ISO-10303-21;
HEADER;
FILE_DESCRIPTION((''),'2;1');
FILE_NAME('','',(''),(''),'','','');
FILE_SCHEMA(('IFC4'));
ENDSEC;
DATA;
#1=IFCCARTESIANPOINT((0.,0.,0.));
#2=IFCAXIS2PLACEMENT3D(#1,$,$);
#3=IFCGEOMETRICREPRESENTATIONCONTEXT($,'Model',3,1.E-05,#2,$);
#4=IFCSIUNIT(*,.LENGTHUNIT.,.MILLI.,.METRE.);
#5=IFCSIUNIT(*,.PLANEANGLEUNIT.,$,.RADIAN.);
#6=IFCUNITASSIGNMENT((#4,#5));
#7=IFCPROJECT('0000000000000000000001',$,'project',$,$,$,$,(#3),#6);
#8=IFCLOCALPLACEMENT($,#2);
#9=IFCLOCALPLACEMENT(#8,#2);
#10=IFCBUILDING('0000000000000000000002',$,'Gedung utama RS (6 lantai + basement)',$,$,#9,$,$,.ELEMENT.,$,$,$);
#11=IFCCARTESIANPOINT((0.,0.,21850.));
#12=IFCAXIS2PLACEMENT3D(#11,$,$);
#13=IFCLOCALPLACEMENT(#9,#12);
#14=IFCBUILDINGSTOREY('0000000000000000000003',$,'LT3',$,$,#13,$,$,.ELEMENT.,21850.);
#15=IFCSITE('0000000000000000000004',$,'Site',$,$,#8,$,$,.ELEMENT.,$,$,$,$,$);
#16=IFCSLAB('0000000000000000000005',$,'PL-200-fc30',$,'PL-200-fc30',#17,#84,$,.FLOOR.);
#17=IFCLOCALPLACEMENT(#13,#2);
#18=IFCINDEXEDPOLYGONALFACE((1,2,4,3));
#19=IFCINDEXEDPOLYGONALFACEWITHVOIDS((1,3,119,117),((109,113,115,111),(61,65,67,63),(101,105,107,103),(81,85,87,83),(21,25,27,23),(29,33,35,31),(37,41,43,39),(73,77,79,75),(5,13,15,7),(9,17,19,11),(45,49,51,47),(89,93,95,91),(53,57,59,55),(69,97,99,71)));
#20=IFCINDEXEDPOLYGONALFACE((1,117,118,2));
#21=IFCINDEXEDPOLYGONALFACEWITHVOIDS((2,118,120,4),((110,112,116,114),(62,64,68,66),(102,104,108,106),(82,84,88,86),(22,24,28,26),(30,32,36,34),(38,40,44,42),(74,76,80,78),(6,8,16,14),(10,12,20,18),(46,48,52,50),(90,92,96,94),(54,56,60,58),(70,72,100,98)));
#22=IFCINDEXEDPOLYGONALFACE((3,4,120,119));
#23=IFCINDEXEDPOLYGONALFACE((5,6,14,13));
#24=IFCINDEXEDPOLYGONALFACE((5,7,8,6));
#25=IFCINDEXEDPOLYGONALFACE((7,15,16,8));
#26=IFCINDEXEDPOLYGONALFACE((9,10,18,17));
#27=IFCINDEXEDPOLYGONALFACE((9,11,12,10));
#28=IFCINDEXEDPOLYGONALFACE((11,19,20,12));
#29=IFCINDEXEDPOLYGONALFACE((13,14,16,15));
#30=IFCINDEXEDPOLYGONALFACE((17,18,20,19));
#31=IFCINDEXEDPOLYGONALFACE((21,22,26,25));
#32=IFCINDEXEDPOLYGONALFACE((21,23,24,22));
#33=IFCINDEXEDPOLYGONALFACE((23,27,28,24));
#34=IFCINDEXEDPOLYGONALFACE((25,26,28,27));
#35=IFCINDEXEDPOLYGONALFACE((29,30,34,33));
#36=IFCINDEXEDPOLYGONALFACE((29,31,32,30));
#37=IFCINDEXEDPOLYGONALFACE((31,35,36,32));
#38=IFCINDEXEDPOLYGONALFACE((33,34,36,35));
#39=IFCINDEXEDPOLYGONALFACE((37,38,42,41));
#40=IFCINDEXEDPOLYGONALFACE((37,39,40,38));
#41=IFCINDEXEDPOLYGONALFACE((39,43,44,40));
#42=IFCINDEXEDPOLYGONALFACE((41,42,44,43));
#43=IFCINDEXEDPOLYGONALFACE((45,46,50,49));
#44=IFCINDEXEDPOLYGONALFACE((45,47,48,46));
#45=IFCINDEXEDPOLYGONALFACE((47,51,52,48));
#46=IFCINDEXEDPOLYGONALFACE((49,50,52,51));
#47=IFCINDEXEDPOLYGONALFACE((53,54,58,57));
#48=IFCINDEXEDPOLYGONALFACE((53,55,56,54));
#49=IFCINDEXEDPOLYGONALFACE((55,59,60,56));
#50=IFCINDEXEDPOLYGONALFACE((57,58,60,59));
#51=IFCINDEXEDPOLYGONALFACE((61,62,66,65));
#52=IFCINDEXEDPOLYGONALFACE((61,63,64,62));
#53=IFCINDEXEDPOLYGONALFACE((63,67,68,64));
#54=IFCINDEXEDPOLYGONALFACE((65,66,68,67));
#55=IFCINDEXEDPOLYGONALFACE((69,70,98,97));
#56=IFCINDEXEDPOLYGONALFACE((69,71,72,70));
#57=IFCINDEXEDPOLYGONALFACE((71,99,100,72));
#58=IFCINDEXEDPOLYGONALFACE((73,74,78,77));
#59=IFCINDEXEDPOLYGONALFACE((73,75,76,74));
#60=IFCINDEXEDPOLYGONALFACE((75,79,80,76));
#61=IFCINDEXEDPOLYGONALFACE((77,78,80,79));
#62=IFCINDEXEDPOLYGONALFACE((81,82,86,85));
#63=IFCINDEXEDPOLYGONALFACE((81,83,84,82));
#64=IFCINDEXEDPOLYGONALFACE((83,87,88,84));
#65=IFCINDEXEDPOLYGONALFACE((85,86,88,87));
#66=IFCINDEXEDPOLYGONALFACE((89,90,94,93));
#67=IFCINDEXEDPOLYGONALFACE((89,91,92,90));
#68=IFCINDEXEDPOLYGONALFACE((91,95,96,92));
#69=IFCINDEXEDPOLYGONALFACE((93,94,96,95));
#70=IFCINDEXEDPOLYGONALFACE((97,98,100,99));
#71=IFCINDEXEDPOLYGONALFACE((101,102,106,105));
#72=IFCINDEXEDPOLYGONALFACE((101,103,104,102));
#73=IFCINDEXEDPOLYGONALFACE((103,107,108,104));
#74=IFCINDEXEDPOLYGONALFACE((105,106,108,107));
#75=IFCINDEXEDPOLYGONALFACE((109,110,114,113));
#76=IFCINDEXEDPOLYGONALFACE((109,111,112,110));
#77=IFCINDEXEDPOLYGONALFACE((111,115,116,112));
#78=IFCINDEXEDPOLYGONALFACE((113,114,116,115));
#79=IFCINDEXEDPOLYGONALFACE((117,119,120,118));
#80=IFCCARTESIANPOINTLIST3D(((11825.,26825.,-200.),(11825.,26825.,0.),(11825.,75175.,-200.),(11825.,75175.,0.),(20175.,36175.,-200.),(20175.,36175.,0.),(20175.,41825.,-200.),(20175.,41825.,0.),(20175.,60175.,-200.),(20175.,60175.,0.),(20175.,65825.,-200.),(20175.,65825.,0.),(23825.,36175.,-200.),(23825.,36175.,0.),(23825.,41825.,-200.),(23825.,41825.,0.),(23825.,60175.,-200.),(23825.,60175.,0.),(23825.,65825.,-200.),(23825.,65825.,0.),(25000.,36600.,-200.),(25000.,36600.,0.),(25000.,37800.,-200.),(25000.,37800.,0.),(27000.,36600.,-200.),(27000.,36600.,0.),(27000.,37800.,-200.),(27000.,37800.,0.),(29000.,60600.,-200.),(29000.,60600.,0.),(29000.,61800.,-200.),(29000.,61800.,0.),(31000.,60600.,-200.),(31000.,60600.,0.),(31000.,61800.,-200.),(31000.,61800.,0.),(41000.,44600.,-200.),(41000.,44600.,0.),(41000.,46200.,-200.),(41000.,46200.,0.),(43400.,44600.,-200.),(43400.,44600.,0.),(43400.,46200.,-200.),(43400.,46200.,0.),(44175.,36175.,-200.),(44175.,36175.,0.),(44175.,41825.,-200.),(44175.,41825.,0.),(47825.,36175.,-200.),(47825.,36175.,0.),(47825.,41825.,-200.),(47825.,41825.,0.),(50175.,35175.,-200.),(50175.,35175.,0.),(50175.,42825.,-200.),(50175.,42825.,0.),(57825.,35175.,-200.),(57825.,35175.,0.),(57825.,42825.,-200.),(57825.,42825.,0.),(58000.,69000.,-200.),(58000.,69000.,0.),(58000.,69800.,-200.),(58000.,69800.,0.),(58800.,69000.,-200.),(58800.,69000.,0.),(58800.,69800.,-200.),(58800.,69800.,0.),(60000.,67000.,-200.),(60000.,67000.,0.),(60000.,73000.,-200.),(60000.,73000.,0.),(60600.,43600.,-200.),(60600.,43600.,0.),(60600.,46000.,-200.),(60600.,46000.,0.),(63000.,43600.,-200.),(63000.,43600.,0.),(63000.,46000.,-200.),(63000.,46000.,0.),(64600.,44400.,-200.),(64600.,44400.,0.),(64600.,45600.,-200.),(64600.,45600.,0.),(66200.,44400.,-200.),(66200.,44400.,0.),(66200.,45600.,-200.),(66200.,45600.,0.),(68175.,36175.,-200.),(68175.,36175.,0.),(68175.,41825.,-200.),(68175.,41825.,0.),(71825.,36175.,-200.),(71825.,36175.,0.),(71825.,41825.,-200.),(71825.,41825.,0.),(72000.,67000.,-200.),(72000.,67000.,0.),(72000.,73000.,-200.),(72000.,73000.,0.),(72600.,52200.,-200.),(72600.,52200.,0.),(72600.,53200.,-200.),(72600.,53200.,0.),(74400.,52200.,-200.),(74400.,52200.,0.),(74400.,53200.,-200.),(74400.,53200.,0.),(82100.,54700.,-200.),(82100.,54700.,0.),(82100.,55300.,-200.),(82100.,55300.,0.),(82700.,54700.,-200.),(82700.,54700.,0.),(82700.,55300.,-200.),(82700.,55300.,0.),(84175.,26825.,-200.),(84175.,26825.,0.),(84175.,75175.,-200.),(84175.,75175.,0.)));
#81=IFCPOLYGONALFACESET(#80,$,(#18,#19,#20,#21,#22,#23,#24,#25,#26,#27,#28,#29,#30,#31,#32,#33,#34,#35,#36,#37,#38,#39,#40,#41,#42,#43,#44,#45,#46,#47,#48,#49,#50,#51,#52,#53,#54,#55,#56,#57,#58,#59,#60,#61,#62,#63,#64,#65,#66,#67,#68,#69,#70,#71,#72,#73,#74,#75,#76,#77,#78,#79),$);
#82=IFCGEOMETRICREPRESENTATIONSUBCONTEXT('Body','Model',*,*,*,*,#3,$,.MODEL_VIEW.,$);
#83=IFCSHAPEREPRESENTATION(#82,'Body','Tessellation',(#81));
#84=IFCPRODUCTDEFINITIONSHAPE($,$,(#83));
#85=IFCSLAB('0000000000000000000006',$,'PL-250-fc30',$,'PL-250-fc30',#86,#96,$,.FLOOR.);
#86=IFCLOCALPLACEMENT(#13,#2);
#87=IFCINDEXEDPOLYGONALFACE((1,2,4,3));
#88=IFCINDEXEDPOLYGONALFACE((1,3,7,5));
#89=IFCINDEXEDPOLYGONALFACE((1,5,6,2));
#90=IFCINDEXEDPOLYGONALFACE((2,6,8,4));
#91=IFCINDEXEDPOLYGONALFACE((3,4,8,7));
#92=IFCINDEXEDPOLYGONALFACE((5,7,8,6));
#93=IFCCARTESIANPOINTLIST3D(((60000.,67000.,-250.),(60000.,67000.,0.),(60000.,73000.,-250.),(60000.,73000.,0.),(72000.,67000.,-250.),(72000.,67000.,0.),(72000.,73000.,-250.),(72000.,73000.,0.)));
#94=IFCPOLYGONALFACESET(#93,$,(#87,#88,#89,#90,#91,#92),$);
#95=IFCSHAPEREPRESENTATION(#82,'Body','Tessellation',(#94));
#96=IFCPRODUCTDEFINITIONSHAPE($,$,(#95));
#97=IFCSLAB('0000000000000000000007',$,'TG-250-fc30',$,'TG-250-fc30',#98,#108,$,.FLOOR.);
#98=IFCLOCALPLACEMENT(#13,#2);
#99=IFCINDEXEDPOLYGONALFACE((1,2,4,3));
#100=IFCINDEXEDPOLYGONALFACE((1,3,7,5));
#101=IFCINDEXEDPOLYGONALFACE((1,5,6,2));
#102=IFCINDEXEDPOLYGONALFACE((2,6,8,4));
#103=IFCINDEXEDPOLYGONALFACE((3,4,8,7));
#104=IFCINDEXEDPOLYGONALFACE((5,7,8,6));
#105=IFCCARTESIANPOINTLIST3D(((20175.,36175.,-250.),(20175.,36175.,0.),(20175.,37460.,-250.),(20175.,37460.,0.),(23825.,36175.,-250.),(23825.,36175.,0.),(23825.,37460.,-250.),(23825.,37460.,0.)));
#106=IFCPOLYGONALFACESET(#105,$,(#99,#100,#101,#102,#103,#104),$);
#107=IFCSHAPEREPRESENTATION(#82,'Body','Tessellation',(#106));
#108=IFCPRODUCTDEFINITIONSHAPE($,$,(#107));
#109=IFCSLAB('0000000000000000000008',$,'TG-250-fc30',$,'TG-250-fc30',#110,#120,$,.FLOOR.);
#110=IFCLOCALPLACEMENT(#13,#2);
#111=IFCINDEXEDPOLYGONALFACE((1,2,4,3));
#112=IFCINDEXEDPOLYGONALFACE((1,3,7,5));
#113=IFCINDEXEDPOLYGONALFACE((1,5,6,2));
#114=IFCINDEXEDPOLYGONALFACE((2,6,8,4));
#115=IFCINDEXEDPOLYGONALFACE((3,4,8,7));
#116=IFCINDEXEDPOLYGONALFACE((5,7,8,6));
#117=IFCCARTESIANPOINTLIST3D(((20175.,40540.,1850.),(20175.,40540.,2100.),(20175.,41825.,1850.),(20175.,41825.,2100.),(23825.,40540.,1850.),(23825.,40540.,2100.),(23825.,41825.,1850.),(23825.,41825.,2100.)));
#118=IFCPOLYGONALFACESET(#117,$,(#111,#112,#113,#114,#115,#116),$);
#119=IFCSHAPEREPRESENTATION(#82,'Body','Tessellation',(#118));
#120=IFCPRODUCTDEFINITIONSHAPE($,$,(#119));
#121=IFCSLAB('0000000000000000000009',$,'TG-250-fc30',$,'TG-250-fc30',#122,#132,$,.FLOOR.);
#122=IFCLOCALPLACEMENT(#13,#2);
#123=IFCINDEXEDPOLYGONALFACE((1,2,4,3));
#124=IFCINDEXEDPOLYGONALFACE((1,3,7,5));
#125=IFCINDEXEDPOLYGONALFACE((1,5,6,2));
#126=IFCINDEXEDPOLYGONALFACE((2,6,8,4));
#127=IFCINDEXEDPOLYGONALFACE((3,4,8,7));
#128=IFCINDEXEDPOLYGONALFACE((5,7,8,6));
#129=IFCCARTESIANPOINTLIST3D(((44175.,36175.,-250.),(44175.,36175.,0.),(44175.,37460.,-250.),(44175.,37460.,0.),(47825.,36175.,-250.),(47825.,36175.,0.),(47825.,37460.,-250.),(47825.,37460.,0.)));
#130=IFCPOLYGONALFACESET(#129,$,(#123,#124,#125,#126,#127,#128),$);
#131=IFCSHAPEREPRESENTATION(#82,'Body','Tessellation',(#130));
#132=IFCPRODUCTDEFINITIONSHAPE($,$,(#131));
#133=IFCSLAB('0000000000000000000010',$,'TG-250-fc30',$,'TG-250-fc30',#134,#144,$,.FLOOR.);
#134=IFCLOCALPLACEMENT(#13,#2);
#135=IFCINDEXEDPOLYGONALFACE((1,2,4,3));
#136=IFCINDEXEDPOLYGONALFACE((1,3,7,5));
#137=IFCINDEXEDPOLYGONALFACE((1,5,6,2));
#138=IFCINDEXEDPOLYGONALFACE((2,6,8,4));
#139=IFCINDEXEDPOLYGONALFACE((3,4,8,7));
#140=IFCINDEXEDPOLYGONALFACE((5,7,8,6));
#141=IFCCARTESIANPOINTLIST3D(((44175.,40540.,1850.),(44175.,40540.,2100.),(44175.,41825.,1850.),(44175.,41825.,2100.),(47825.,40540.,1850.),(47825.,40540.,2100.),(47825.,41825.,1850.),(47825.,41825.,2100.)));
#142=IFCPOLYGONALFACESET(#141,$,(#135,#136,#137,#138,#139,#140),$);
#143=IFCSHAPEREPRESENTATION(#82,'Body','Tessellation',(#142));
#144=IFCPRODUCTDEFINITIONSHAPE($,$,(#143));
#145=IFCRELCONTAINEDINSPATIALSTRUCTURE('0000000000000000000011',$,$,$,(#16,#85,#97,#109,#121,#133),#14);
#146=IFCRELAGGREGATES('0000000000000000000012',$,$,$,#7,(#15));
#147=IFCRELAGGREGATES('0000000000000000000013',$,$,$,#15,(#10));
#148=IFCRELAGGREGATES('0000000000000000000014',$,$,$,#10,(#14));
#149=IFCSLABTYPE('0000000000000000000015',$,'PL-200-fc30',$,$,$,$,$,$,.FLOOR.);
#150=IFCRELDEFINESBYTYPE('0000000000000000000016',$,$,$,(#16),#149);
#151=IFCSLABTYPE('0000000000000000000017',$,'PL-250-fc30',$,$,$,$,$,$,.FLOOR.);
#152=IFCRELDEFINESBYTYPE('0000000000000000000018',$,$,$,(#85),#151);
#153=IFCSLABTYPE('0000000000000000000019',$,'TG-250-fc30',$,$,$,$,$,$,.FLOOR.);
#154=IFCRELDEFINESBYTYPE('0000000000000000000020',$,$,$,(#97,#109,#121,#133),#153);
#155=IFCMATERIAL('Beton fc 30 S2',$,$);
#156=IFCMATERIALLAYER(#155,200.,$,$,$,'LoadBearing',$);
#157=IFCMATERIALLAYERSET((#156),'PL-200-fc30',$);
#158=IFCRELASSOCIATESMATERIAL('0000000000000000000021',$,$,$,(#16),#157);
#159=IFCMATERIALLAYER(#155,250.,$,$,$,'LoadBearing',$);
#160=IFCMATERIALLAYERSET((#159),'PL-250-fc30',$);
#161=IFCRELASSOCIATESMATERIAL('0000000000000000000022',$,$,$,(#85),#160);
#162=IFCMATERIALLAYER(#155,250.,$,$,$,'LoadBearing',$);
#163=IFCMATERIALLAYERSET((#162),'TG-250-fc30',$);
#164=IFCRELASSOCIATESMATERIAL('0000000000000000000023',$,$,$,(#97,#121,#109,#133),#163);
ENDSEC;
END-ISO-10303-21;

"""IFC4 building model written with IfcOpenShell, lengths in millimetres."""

from ifc_helpers import new_model, si_unit, frame, origin, place, context, subcontext, project, spatial, polyline, outline, extrude, material, layer, layer_set, layer_usage, type_object, element, save


model = new_model("IFC4")

# Units and contexts
model_context = context("Model", 3, precision=1e-05, world=origin())
body_context = subcontext(model_context, "Body", "Model", "MODEL_VIEW")
ifc_project = project(units=[si_unit("LENGTHUNIT", "METRE", prefix="MILLI"), si_unit("PLANEANGLEUNIT", "RADIAN")], contexts=[model_context])

# Site, building, storey
site_placement = place(None, origin())
site = spatial("IfcSite", under=ifc_project, at=site_placement, Name="Site", CompositionType="ELEMENT")
building_placement = place(site_placement, origin())
building = spatial("IfcBuilding", under=site, at=building_placement, Name="Gedung utama RS (6 lantai + basement)", CompositionType="ELEMENT")
storey_placement = place(building_placement, frame((0.0, 0.0, 21850.0)))
storey = spatial("IfcBuildingStorey", under=building, at=storey_placement, Name="LT3", CompositionType="ELEMENT", Elevation=21850.0)

# Shared definitions
ifc_material_1 = material(Name="Beton fc 30 S2")

# Slab, openings
ifc_layer_1 = layer(ifc_material_1, 200.0, Category="LoadBearing")
ifc_layer_set_1 = layer_set([ifc_layer_1], Name="PL-200-fc30")
ifc_layer_usage_1 = layer_usage(ifc_layer_set_1, "AXIS3", "NEGATIVE", 0.0)
slab_type_1 = type_object("IfcSlabType", Name="PL-200-fc30", PredefinedType="FLOOR")
slab_1_placement = place(storey_placement, origin())
slab_1 = element("IfcSlab", 1, at=slab_1_placement, inside=storey, type_object=slab_type_1, material=ifc_layer_usage_1, Name="PL-200-fc30", ObjectType="PL-200-fc30", PredefinedType="FLOOR", context=body_context, shape_type="SweptSolid", body=[
    extrude(outline(polyline([(84175.0, 26825.0), (84175.0, 75175.0), (11825.0, 75175.0), (11825.0, 26825.0), (84175.0, 26825.0)]), holes=[polyline([(23825.0, 36175.0), (23825.0, 41825.0), (20175.0, 41825.0), (20175.0, 36175.0), (23825.0, 36175.0)]), polyline([(47825.0, 36175.0), (47825.0, 41825.0), (44175.0, 41825.0), (44175.0, 36175.0), (47825.0, 36175.0)]), polyline([(71825.0, 36175.0), (71825.0, 41825.0), (68175.0, 41825.0), (68175.0, 36175.0), (71825.0, 36175.0)]), polyline([(23825.0, 60175.0), (23825.0, 65825.0), (20175.0, 65825.0), (20175.0, 60175.0), (23825.0, 60175.0)]), polyline([(72000.0, 67000.0), (72000.0, 73000.0), (60000.0, 73000.0), (60000.0, 67000.0), (72000.0, 67000.0)])]), frame((0.0, 0.0, -200.0)), (0.0, 0.0, 1.0), 200.0),
])
opening_1_placement = place(slab_1_placement, frame((0.0, 0.0, -8900.0)))
element("IfcOpeningElement", 2, at=opening_1_placement, cuts=slab_1, PredefinedType="OPENING", context=body_context, shape_type="SweptSolid", body=[
    extrude(outline(polyline([(27000.0, 36600.0), (27000.0, 37800.0), (25000.0, 37800.0), (25000.0, 36600.0), (27000.0, 36600.0)])), origin(), (0.0, 0.0, 1.0), 25800.0),
])
opening_2_placement = place(slab_1_placement, frame((0.0, 0.0, -8900.0)))
element("IfcOpeningElement", 3, at=opening_2_placement, cuts=slab_1, PredefinedType="OPENING", context=body_context, shape_type="SweptSolid", body=[
    extrude(outline(polyline([(43400.0, 44600.0), (43400.0, 46200.0), (41000.0, 46200.0), (41000.0, 44600.0), (43400.0, 44600.0)])), origin(), (0.0, 0.0, 1.0), 25800.0),
])
opening_3_placement = place(slab_1_placement, frame((0.0, 0.0, -8900.0)))
element("IfcOpeningElement", 4, at=opening_3_placement, cuts=slab_1, PredefinedType="OPENING", context=body_context, shape_type="SweptSolid", body=[
    extrude(outline(polyline([(66200.0, 44400.0), (66200.0, 45600.0), (64600.0, 45600.0), (64600.0, 44400.0), (66200.0, 44400.0)])), origin(), (0.0, 0.0, 1.0), 25800.0),
])
opening_4_placement = place(slab_1_placement, frame((0.0, 0.0, -4400.0)))
element("IfcOpeningElement", 5, at=opening_4_placement, cuts=slab_1, PredefinedType="OPENING", context=body_context, shape_type="SweptSolid", body=[
    extrude(outline(polyline([(63000.0, 43600.0), (63000.0, 46000.0), (60600.0, 46000.0), (60600.0, 43600.0), (63000.0, 43600.0)])), origin(), (0.0, 0.0, 1.0), 4500.0),
])
opening_5_placement = place(slab_1_placement, frame((0.0, 0.0, -8900.0)))
element("IfcOpeningElement", 6, at=opening_5_placement, cuts=slab_1, PredefinedType="OPENING", context=body_context, shape_type="SweptSolid", body=[
    extrude(outline(polyline([(31000.0, 60600.0), (31000.0, 61800.0), (29000.0, 61800.0), (29000.0, 60600.0), (31000.0, 60600.0)])), origin(), (0.0, 0.0, 1.0), 13200.0),
])
opening_6_placement = place(slab_1_placement, frame((0.0, 0.0, -8900.0)))
element("IfcOpeningElement", 7, at=opening_6_placement, cuts=slab_1, PredefinedType="OPENING", context=body_context, shape_type="SweptSolid", body=[
    extrude(outline(polyline([(82700.0, 54700.0), (82700.0, 55300.0), (82100.0, 55300.0), (82100.0, 54700.0), (82700.0, 54700.0)])), origin(), (0.0, 0.0, 1.0), 9000.0),
])
opening_7_placement = place(slab_1_placement, frame((0.0, 0.0, -4400.0)))
element("IfcOpeningElement", 8, at=opening_7_placement, cuts=slab_1, PredefinedType="OPENING", context=body_context, shape_type="SweptSolid", body=[
    extrude(outline(polyline([(74400.0, 52200.0), (74400.0, 53200.0), (72600.0, 53200.0), (72600.0, 52200.0), (74400.0, 52200.0)])), origin(), (0.0, 0.0, 1.0), 4500.0),
])
opening_8_placement = place(slab_1_placement, frame((0.0, 0.0, -4400.0)))
element("IfcOpeningElement", 9, at=opening_8_placement, cuts=slab_1, PredefinedType="OPENING", context=body_context, shape_type="SweptSolid", body=[
    extrude(outline(polyline([(58800.0, 69000.0), (58800.0, 69800.0), (58000.0, 69800.0), (58000.0, 69000.0), (58800.0, 69000.0)])), origin(), (0.0, 0.0, 1.0), 4500.0),
])
opening_9_placement = place(slab_1_placement, frame((0.0, 0.0, -8900.0)))
element("IfcOpeningElement", 10, at=opening_9_placement, cuts=slab_1, PredefinedType="OPENING", context=body_context, shape_type="SweptSolid", body=[
    extrude(outline(polyline([(57825.0, 35175.0), (57825.0, 42825.0), (50175.0, 42825.0), (50175.0, 35175.0), (57825.0, 35175.0)])), origin(), (0.0, 0.0, 1.0), 21600.0),
])

# Slabs
ifc_layer_2 = layer(ifc_material_1, 250.0, Category="LoadBearing")
ifc_layer_set_2 = layer_set([ifc_layer_2], Name="PL-250-fc30")
ifc_layer_usage_2 = layer_usage(ifc_layer_set_2, "AXIS3", "NEGATIVE", 0.0)
slab_type_2 = type_object("IfcSlabType", Name="PL-250-fc30", PredefinedType="FLOOR")
slab_2_placement = place(storey_placement, origin())
element("IfcSlab", 11, at=slab_2_placement, inside=storey, type_object=slab_type_2, material=ifc_layer_usage_2, Name="PL-250-fc30", ObjectType="PL-250-fc30", PredefinedType="FLOOR", context=body_context, shape_type="SweptSolid", body=[
    extrude(outline(polyline([(72000.0, 67000.0), (72000.0, 73000.0), (60000.0, 73000.0), (60000.0, 67000.0), (72000.0, 67000.0)])), frame((0.0, 0.0, -250.0)), (0.0, 0.0, 1.0), 250.0),
])
ifc_layer_3 = layer(ifc_material_1, 250.0, Category="LoadBearing")
ifc_layer_set_3 = layer_set([ifc_layer_3], Name="TG-250-fc30")
ifc_layer_usage_3 = layer_usage(ifc_layer_set_3, "AXIS3", "NEGATIVE", 0.0)
slab_type_3 = type_object("IfcSlabType", Name="TG-250-fc30", PredefinedType="FLOOR")
slab_3_placement = place(storey_placement, origin())
element("IfcSlab", 12, at=slab_3_placement, inside=storey, type_object=slab_type_3, material=ifc_layer_usage_3, Name="TG-250-fc30", ObjectType="TG-250-fc30", PredefinedType="FLOOR", context=body_context, shape_type="SweptSolid", body=[
    extrude(outline(polyline([(23825.0, 36175.0), (23825.0, 37460.0), (20175.0, 37460.0), (20175.0, 36175.0), (23825.0, 36175.0)])), frame((0.0, 0.0, -250.0)), (0.0, 0.0, 1.0), 250.0),
])
ifc_layer_usage_4 = layer_usage(ifc_layer_set_3, "AXIS3", "NEGATIVE", 2100.0)
slab_4_placement = place(storey_placement, origin())
element("IfcSlab", 13, at=slab_4_placement, inside=storey, type_object=slab_type_3, material=ifc_layer_usage_4, Name="TG-250-fc30", ObjectType="TG-250-fc30", PredefinedType="FLOOR", context=body_context, shape_type="SweptSolid", body=[
    extrude(outline(polyline([(23825.0, 40540.0), (23825.0, 41825.0), (20175.0, 41825.0), (20175.0, 40540.0), (23825.0, 40540.0)])), frame((0.0, 0.0, 1850.0)), (0.0, 0.0, 1.0), 250.0),
])
slab_5_placement = place(storey_placement, origin())
element("IfcSlab", 14, at=slab_5_placement, inside=storey, type_object=slab_type_3, material=ifc_layer_usage_3, Name="TG-250-fc30", ObjectType="TG-250-fc30", PredefinedType="FLOOR", context=body_context, shape_type="SweptSolid", body=[
    extrude(outline(polyline([(47825.0, 36175.0), (47825.0, 37460.0), (44175.0, 37460.0), (44175.0, 36175.0), (47825.0, 36175.0)])), frame((0.0, 0.0, -250.0)), (0.0, 0.0, 1.0), 250.0),
])
slab_6_placement = place(storey_placement, origin())
element("IfcSlab", 15, at=slab_6_placement, inside=storey, type_object=slab_type_3, material=ifc_layer_usage_4, Name="TG-250-fc30", ObjectType="TG-250-fc30", PredefinedType="FLOOR", context=body_context, shape_type="SweptSolid", body=[
    extrude(outline(polyline([(47825.0, 40540.0), (47825.0, 41825.0), (44175.0, 41825.0), (44175.0, 40540.0), (47825.0, 40540.0)])), frame((0.0, 0.0, 1850.0)), (0.0, 0.0, 1.0), 250.0),
])

save(model, "model.ifc")
